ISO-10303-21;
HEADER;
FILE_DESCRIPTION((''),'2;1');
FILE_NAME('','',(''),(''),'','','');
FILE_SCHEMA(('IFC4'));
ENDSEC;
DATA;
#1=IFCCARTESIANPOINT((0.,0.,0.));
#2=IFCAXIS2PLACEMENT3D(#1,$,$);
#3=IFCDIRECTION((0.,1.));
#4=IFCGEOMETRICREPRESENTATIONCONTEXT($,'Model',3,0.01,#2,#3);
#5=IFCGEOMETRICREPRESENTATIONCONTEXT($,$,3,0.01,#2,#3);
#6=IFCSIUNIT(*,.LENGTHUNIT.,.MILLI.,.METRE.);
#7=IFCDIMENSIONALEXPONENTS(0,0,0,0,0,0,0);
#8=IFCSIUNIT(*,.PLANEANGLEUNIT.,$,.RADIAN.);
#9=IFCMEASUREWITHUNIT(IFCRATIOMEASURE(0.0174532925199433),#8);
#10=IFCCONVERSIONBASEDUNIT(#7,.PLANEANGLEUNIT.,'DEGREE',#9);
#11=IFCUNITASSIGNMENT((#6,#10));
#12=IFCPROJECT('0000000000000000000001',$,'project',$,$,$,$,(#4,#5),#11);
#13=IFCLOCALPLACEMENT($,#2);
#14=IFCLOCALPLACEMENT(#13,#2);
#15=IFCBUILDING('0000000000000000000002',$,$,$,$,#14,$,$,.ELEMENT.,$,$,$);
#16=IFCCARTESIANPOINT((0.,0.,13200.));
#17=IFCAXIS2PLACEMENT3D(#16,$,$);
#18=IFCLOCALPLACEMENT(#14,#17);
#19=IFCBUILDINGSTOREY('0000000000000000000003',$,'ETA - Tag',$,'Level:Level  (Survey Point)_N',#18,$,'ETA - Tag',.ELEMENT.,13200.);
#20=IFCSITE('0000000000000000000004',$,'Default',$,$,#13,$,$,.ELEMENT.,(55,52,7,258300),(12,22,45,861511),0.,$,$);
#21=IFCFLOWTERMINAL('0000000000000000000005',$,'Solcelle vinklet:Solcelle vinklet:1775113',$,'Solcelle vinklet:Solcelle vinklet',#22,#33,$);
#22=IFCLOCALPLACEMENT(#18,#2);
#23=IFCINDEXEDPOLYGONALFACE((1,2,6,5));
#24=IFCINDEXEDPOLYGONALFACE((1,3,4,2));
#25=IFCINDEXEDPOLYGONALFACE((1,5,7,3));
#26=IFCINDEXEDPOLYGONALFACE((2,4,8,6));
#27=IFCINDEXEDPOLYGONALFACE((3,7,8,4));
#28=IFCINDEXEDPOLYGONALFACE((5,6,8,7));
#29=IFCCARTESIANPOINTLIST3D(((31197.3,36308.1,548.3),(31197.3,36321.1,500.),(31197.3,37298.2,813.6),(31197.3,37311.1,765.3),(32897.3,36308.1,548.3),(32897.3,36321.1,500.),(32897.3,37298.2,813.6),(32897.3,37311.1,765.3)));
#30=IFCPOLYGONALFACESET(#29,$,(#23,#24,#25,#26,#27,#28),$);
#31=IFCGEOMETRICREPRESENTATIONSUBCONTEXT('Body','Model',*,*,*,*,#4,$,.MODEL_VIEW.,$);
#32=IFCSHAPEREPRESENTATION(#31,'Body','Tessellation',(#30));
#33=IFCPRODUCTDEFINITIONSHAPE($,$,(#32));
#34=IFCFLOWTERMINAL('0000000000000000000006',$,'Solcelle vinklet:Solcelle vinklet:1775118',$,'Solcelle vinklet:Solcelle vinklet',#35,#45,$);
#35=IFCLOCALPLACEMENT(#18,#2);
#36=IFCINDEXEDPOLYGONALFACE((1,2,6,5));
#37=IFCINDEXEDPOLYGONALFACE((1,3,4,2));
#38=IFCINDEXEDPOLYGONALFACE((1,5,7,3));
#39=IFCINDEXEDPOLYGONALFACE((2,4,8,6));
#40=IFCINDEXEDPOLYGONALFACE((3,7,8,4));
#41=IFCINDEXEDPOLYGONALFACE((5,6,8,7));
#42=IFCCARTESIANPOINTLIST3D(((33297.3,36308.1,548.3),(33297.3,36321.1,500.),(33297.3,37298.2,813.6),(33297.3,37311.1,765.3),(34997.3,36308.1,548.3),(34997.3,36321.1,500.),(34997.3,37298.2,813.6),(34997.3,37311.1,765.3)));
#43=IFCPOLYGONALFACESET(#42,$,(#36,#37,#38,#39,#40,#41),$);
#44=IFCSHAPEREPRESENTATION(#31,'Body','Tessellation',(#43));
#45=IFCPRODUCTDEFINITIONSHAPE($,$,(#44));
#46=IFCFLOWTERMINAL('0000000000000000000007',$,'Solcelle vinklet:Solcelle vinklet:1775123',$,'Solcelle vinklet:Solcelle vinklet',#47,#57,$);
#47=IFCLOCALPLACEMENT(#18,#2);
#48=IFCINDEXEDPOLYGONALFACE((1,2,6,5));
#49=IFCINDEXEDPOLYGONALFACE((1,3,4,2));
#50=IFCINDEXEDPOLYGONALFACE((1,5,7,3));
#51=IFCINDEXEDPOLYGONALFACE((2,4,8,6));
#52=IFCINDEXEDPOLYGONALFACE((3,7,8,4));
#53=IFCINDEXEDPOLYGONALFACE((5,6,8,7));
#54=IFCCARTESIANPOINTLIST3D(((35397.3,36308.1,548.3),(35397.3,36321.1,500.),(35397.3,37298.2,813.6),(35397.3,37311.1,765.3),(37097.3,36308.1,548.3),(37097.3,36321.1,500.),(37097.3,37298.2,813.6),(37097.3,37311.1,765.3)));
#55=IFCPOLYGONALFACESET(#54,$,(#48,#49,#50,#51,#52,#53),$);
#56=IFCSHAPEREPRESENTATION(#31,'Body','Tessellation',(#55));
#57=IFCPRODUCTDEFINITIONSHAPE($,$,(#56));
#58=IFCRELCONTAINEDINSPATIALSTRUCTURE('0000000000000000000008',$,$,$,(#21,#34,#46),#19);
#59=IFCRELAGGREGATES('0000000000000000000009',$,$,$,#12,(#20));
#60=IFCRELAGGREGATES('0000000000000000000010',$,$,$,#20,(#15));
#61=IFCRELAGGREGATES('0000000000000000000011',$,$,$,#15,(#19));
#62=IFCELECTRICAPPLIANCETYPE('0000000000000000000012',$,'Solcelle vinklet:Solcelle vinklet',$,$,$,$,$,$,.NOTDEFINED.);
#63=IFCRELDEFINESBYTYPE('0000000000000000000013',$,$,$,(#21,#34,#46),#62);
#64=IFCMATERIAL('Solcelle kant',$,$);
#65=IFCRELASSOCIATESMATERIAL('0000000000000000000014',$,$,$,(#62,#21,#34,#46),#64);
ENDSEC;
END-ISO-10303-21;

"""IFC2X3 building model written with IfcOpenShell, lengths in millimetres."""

from ifc_helpers import new_model, entity, si_unit, converted_unit, direction, frame, frame_2d, origin, place, context, subcontext, project, spatial, rectangle, extrude, source, transform, mapped, material, type_object, type_shapes, element, save


model = new_model("IFC2X3")

# Units and contexts
model_context = context("Model", 3, precision=0.01, world=origin(), true_north=direction((0.0, 1.0)))
context_of_model = context(None, 3, precision=0.01, world=origin(), true_north=direction((0.0, 1.0)))
body_context = subcontext(model_context, "Body", "Model", "MODEL_VIEW")
ifc_project = project(units=[si_unit("LENGTHUNIT", "METRE", prefix="MILLI"), converted_unit("PLANEANGLEUNIT", "DEGREE", entity("IfcRatioMeasure", 0.0174532925199433), si_unit("PLANEANGLEUNIT", "RADIAN"), dimensions=[0, 0, 0, 0, 0, 0, 0])], contexts=[model_context, context_of_model])

# Site, building, storey
site_placement = place(None, origin())
site = spatial("IfcSite", under=ifc_project, at=site_placement, Name="Default", CompositionType="ELEMENT", RefLatitude=(55, 52, 7, 258300), RefLongitude=(12, 22, 45, 861511), RefElevation=0.0)
building_placement = place(site_placement, origin())
building = spatial("IfcBuilding", under=site, at=building_placement, CompositionType="ELEMENT")
storey_placement = place(building_placement, frame((0.0, 0.0, 13200.0)))
storey = spatial("IfcBuildingStorey", under=building, at=storey_placement, Name="ETA - Tag", ObjectType="Level:Level  (Survey Point)_N", LongName="ETA - Tag", CompositionType="ELEMENT", Elevation=13200.0)

# Flow terminals
ifc_material = material(Name="Solcelle kant")
electric_appliance_type = type_object("IfcElectricApplianceType", Name="Solcelle vinklet:Solcelle vinklet", PredefinedType="NOTDEFINED", material=ifc_material)
shared_shape = source(origin(), body_context, "Body", "SweptSolid", [
    extrude(rectangle(XDim=50.0, YDim=1025.0, at=frame_2d((0.0, 0.0), x_axis=(1.0, 0.0))), frame((-850.0, 488.6, 156.8), z_axis=(1.0, 0.0, 0.0), x_axis=(0.0, 0.258819, -0.965926)), (0.0, 0.0, 1.0), 1700.0),
])
type_shapes(electric_appliance_type, [shared_shape])
for number, where, name in (
    (1, (32047.3, 36321.1, 500.0), "Solcelle vinklet:Solcelle vinklet:1775113"),
    (2, (34147.3, 36321.1, 500.0), "Solcelle vinklet:Solcelle vinklet:1775118"),
    (3, (36247.3, 36321.1, 500.0), "Solcelle vinklet:Solcelle vinklet:1775123"),
):
    element("IfcFlowTerminal", number, at=place(storey_placement, frame(where)), inside=storey, type_object=electric_appliance_type, material=ifc_material, Name=name, ObjectType="Solcelle vinklet:Solcelle vinklet", context=body_context, shape_type="MappedRepresentation", body=[
        mapped(shared_shape, transform((0.0, 0.0, 0.0), scale=1.0)),
    ])

save(model, "model.ifc")
